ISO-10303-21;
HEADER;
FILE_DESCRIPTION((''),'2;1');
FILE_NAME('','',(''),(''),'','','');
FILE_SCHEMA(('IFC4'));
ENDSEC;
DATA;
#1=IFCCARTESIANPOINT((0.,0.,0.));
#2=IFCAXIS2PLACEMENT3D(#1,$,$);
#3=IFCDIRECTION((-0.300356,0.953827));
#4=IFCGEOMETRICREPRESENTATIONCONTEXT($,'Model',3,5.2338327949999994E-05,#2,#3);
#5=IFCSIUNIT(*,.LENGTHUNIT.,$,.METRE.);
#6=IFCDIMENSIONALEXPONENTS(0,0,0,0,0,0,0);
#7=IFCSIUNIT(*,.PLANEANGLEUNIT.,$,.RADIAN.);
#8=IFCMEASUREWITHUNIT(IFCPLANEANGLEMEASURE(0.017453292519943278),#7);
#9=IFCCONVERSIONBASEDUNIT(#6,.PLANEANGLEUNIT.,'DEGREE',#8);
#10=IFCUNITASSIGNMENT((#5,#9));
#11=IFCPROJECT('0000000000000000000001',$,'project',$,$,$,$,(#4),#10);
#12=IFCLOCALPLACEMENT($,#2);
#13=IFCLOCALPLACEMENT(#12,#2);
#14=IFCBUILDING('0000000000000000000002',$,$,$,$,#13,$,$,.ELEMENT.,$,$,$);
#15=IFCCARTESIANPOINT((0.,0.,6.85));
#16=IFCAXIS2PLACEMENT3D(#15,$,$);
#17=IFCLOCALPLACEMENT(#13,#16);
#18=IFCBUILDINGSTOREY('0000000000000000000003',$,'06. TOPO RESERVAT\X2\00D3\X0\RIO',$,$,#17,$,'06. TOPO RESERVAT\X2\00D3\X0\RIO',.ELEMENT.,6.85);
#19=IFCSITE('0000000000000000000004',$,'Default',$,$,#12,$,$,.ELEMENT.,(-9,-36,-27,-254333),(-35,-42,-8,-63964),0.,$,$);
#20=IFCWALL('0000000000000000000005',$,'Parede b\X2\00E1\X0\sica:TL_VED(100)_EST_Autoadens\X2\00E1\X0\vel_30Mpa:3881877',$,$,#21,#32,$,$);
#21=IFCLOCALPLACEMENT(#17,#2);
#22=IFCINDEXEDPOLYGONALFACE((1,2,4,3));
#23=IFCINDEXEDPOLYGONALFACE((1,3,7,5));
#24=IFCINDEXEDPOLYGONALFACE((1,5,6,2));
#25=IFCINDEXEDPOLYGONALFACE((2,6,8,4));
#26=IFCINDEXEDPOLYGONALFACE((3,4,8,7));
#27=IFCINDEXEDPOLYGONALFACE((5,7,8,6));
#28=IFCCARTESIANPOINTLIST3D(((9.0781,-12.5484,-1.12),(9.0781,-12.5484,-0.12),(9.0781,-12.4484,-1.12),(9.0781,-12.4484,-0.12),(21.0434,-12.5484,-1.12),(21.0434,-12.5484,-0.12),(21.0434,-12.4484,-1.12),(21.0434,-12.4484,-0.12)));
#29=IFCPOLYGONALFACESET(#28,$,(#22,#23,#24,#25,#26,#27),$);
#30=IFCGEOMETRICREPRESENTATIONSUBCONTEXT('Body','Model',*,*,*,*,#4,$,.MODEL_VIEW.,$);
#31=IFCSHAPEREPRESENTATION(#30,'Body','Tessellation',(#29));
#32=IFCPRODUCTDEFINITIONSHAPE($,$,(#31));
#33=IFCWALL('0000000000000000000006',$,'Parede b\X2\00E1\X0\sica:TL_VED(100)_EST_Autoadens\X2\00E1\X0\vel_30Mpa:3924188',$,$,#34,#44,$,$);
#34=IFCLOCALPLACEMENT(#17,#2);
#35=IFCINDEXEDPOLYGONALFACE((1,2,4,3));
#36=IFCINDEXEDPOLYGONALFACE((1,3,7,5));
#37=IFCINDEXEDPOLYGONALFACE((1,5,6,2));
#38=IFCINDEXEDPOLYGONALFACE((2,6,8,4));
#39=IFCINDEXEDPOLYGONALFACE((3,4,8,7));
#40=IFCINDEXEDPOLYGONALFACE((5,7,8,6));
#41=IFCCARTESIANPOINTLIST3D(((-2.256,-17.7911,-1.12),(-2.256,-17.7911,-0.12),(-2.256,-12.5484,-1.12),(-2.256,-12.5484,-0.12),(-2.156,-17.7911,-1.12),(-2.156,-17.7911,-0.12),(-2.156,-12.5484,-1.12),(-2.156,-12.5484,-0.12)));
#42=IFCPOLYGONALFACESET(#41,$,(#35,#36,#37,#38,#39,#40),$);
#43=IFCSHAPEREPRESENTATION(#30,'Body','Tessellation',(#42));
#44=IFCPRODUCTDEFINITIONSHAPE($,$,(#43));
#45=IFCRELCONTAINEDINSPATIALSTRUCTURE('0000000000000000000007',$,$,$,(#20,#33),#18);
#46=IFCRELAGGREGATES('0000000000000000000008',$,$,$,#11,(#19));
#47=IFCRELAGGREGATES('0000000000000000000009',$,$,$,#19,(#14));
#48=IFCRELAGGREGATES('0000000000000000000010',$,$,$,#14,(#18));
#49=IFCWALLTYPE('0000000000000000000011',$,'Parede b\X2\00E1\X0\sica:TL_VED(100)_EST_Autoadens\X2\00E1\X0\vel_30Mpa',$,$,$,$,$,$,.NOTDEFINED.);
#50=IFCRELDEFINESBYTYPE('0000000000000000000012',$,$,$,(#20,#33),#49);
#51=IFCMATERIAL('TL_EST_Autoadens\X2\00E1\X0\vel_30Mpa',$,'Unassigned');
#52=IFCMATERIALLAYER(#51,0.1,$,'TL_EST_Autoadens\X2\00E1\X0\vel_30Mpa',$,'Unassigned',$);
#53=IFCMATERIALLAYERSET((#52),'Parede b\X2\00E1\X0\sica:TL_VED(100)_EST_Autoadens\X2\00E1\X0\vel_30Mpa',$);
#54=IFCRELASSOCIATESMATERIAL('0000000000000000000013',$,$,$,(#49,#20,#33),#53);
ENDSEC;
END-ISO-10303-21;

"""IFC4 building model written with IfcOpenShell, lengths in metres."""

from ifc_helpers import new_model, entity, si_unit, converted_unit, direction, frame, frame_2d, origin, place, context, subcontext, project, spatial, rectangle, extrude, material, layer, layer_set, layer_usage, type_object, element, save


model = new_model("IFC4")

# Units and contexts
model_context = context("Model", 3, precision=5.2338327949999994e-05, world=origin(), true_north=direction((-0.300356, 0.953827)))
body_context = subcontext(model_context, "Body", "Model", "MODEL_VIEW")
ifc_project = project(units=[si_unit("LENGTHUNIT", "METRE"), converted_unit("PLANEANGLEUNIT", "DEGREE", entity("IfcPlaneAngleMeasure", 0.017453292519943278), si_unit("PLANEANGLEUNIT", "RADIAN"), dimensions=[0, 0, 0, 0, 0, 0, 0])], contexts=[model_context])

# Site, building, storey
site_placement = place(None, origin())
site = spatial("IfcSite", under=ifc_project, at=site_placement, Name="Default", CompositionType="ELEMENT", RefLatitude=(-9, -36, -27, -254333), RefLongitude=(-35, -42, -8, -63964), RefElevation=0.0)
building_placement = place(site_placement, origin())
building = spatial("IfcBuilding", under=site, at=building_placement, CompositionType="ELEMENT")
storey_placement = place(building_placement, frame((0.0, 0.0, 6.85)))
storey = spatial("IfcBuildingStorey", under=building, at=storey_placement, Name="06. TOPO RESERVATÓRIO", LongName="06. TOPO RESERVATÓRIO", CompositionType="ELEMENT", Elevation=6.85)

# Walls
ifc_material_1 = material(Name="TL_EST_Autoadensável_30Mpa", Category="Unassigned")
ifc_layer_1 = layer(ifc_material_1, 0.1, Name="TL_EST_Autoadensável_30Mpa", Category="Unassigned")
ifc_layer_set_1 = layer_set([ifc_layer_1], Name="Parede básica:TL_VED(100)_EST_Autoadensável_30Mpa")
ifc_layer_usage_1 = layer_usage(ifc_layer_set_1, "AXIS2", "POSITIVE", -0.05)
wall_type = type_object("IfcWallType", Name="Parede básica:TL_VED(100)_EST_Autoadensável_30Mpa", PredefinedType="NOTDEFINED", material=ifc_layer_set_1)
wall_1_placement = place(storey_placement, frame((9.0781, -12.4984, -1.12)))
element("IfcWall", 1, at=wall_1_placement, inside=storey, type_object=wall_type, material=ifc_layer_usage_1, Name="Parede básica:TL_VED(100)_EST_Autoadensável_30Mpa:3881877", context=body_context, shape_type="SweptSolid", body=[
    extrude(rectangle(XDim=11.9653, YDim=0.1, at=frame_2d((5.9826, 0.0), x_axis=(-1.0, 0.0))), origin(), (0.0, 0.0, 1.0), 1.0),
])
ifc_layer_usage_2 = layer_usage(ifc_layer_set_1, "AXIS2", "NEGATIVE", 0.05)
wall_2_placement = place(storey_placement, frame((-2.206, -12.5484, -1.12), z_axis=(0.0, 0.0, 1.0), x_axis=(0.0, -1.0, 0.0)))
element("IfcWall", 2, at=wall_2_placement, inside=storey, type_object=wall_type, material=ifc_layer_usage_2, Name="Parede básica:TL_VED(100)_EST_Autoadensável_30Mpa:3924188", context=body_context, shape_type="SweptSolid", body=[
    extrude(rectangle(XDim=5.2427, YDim=0.1, at=frame_2d((2.6214, 0.0), x_axis=(-1.0, 0.0))), origin(), (0.0, 0.0, 1.0), 1.0),
])

save(model, "model.ifc")
